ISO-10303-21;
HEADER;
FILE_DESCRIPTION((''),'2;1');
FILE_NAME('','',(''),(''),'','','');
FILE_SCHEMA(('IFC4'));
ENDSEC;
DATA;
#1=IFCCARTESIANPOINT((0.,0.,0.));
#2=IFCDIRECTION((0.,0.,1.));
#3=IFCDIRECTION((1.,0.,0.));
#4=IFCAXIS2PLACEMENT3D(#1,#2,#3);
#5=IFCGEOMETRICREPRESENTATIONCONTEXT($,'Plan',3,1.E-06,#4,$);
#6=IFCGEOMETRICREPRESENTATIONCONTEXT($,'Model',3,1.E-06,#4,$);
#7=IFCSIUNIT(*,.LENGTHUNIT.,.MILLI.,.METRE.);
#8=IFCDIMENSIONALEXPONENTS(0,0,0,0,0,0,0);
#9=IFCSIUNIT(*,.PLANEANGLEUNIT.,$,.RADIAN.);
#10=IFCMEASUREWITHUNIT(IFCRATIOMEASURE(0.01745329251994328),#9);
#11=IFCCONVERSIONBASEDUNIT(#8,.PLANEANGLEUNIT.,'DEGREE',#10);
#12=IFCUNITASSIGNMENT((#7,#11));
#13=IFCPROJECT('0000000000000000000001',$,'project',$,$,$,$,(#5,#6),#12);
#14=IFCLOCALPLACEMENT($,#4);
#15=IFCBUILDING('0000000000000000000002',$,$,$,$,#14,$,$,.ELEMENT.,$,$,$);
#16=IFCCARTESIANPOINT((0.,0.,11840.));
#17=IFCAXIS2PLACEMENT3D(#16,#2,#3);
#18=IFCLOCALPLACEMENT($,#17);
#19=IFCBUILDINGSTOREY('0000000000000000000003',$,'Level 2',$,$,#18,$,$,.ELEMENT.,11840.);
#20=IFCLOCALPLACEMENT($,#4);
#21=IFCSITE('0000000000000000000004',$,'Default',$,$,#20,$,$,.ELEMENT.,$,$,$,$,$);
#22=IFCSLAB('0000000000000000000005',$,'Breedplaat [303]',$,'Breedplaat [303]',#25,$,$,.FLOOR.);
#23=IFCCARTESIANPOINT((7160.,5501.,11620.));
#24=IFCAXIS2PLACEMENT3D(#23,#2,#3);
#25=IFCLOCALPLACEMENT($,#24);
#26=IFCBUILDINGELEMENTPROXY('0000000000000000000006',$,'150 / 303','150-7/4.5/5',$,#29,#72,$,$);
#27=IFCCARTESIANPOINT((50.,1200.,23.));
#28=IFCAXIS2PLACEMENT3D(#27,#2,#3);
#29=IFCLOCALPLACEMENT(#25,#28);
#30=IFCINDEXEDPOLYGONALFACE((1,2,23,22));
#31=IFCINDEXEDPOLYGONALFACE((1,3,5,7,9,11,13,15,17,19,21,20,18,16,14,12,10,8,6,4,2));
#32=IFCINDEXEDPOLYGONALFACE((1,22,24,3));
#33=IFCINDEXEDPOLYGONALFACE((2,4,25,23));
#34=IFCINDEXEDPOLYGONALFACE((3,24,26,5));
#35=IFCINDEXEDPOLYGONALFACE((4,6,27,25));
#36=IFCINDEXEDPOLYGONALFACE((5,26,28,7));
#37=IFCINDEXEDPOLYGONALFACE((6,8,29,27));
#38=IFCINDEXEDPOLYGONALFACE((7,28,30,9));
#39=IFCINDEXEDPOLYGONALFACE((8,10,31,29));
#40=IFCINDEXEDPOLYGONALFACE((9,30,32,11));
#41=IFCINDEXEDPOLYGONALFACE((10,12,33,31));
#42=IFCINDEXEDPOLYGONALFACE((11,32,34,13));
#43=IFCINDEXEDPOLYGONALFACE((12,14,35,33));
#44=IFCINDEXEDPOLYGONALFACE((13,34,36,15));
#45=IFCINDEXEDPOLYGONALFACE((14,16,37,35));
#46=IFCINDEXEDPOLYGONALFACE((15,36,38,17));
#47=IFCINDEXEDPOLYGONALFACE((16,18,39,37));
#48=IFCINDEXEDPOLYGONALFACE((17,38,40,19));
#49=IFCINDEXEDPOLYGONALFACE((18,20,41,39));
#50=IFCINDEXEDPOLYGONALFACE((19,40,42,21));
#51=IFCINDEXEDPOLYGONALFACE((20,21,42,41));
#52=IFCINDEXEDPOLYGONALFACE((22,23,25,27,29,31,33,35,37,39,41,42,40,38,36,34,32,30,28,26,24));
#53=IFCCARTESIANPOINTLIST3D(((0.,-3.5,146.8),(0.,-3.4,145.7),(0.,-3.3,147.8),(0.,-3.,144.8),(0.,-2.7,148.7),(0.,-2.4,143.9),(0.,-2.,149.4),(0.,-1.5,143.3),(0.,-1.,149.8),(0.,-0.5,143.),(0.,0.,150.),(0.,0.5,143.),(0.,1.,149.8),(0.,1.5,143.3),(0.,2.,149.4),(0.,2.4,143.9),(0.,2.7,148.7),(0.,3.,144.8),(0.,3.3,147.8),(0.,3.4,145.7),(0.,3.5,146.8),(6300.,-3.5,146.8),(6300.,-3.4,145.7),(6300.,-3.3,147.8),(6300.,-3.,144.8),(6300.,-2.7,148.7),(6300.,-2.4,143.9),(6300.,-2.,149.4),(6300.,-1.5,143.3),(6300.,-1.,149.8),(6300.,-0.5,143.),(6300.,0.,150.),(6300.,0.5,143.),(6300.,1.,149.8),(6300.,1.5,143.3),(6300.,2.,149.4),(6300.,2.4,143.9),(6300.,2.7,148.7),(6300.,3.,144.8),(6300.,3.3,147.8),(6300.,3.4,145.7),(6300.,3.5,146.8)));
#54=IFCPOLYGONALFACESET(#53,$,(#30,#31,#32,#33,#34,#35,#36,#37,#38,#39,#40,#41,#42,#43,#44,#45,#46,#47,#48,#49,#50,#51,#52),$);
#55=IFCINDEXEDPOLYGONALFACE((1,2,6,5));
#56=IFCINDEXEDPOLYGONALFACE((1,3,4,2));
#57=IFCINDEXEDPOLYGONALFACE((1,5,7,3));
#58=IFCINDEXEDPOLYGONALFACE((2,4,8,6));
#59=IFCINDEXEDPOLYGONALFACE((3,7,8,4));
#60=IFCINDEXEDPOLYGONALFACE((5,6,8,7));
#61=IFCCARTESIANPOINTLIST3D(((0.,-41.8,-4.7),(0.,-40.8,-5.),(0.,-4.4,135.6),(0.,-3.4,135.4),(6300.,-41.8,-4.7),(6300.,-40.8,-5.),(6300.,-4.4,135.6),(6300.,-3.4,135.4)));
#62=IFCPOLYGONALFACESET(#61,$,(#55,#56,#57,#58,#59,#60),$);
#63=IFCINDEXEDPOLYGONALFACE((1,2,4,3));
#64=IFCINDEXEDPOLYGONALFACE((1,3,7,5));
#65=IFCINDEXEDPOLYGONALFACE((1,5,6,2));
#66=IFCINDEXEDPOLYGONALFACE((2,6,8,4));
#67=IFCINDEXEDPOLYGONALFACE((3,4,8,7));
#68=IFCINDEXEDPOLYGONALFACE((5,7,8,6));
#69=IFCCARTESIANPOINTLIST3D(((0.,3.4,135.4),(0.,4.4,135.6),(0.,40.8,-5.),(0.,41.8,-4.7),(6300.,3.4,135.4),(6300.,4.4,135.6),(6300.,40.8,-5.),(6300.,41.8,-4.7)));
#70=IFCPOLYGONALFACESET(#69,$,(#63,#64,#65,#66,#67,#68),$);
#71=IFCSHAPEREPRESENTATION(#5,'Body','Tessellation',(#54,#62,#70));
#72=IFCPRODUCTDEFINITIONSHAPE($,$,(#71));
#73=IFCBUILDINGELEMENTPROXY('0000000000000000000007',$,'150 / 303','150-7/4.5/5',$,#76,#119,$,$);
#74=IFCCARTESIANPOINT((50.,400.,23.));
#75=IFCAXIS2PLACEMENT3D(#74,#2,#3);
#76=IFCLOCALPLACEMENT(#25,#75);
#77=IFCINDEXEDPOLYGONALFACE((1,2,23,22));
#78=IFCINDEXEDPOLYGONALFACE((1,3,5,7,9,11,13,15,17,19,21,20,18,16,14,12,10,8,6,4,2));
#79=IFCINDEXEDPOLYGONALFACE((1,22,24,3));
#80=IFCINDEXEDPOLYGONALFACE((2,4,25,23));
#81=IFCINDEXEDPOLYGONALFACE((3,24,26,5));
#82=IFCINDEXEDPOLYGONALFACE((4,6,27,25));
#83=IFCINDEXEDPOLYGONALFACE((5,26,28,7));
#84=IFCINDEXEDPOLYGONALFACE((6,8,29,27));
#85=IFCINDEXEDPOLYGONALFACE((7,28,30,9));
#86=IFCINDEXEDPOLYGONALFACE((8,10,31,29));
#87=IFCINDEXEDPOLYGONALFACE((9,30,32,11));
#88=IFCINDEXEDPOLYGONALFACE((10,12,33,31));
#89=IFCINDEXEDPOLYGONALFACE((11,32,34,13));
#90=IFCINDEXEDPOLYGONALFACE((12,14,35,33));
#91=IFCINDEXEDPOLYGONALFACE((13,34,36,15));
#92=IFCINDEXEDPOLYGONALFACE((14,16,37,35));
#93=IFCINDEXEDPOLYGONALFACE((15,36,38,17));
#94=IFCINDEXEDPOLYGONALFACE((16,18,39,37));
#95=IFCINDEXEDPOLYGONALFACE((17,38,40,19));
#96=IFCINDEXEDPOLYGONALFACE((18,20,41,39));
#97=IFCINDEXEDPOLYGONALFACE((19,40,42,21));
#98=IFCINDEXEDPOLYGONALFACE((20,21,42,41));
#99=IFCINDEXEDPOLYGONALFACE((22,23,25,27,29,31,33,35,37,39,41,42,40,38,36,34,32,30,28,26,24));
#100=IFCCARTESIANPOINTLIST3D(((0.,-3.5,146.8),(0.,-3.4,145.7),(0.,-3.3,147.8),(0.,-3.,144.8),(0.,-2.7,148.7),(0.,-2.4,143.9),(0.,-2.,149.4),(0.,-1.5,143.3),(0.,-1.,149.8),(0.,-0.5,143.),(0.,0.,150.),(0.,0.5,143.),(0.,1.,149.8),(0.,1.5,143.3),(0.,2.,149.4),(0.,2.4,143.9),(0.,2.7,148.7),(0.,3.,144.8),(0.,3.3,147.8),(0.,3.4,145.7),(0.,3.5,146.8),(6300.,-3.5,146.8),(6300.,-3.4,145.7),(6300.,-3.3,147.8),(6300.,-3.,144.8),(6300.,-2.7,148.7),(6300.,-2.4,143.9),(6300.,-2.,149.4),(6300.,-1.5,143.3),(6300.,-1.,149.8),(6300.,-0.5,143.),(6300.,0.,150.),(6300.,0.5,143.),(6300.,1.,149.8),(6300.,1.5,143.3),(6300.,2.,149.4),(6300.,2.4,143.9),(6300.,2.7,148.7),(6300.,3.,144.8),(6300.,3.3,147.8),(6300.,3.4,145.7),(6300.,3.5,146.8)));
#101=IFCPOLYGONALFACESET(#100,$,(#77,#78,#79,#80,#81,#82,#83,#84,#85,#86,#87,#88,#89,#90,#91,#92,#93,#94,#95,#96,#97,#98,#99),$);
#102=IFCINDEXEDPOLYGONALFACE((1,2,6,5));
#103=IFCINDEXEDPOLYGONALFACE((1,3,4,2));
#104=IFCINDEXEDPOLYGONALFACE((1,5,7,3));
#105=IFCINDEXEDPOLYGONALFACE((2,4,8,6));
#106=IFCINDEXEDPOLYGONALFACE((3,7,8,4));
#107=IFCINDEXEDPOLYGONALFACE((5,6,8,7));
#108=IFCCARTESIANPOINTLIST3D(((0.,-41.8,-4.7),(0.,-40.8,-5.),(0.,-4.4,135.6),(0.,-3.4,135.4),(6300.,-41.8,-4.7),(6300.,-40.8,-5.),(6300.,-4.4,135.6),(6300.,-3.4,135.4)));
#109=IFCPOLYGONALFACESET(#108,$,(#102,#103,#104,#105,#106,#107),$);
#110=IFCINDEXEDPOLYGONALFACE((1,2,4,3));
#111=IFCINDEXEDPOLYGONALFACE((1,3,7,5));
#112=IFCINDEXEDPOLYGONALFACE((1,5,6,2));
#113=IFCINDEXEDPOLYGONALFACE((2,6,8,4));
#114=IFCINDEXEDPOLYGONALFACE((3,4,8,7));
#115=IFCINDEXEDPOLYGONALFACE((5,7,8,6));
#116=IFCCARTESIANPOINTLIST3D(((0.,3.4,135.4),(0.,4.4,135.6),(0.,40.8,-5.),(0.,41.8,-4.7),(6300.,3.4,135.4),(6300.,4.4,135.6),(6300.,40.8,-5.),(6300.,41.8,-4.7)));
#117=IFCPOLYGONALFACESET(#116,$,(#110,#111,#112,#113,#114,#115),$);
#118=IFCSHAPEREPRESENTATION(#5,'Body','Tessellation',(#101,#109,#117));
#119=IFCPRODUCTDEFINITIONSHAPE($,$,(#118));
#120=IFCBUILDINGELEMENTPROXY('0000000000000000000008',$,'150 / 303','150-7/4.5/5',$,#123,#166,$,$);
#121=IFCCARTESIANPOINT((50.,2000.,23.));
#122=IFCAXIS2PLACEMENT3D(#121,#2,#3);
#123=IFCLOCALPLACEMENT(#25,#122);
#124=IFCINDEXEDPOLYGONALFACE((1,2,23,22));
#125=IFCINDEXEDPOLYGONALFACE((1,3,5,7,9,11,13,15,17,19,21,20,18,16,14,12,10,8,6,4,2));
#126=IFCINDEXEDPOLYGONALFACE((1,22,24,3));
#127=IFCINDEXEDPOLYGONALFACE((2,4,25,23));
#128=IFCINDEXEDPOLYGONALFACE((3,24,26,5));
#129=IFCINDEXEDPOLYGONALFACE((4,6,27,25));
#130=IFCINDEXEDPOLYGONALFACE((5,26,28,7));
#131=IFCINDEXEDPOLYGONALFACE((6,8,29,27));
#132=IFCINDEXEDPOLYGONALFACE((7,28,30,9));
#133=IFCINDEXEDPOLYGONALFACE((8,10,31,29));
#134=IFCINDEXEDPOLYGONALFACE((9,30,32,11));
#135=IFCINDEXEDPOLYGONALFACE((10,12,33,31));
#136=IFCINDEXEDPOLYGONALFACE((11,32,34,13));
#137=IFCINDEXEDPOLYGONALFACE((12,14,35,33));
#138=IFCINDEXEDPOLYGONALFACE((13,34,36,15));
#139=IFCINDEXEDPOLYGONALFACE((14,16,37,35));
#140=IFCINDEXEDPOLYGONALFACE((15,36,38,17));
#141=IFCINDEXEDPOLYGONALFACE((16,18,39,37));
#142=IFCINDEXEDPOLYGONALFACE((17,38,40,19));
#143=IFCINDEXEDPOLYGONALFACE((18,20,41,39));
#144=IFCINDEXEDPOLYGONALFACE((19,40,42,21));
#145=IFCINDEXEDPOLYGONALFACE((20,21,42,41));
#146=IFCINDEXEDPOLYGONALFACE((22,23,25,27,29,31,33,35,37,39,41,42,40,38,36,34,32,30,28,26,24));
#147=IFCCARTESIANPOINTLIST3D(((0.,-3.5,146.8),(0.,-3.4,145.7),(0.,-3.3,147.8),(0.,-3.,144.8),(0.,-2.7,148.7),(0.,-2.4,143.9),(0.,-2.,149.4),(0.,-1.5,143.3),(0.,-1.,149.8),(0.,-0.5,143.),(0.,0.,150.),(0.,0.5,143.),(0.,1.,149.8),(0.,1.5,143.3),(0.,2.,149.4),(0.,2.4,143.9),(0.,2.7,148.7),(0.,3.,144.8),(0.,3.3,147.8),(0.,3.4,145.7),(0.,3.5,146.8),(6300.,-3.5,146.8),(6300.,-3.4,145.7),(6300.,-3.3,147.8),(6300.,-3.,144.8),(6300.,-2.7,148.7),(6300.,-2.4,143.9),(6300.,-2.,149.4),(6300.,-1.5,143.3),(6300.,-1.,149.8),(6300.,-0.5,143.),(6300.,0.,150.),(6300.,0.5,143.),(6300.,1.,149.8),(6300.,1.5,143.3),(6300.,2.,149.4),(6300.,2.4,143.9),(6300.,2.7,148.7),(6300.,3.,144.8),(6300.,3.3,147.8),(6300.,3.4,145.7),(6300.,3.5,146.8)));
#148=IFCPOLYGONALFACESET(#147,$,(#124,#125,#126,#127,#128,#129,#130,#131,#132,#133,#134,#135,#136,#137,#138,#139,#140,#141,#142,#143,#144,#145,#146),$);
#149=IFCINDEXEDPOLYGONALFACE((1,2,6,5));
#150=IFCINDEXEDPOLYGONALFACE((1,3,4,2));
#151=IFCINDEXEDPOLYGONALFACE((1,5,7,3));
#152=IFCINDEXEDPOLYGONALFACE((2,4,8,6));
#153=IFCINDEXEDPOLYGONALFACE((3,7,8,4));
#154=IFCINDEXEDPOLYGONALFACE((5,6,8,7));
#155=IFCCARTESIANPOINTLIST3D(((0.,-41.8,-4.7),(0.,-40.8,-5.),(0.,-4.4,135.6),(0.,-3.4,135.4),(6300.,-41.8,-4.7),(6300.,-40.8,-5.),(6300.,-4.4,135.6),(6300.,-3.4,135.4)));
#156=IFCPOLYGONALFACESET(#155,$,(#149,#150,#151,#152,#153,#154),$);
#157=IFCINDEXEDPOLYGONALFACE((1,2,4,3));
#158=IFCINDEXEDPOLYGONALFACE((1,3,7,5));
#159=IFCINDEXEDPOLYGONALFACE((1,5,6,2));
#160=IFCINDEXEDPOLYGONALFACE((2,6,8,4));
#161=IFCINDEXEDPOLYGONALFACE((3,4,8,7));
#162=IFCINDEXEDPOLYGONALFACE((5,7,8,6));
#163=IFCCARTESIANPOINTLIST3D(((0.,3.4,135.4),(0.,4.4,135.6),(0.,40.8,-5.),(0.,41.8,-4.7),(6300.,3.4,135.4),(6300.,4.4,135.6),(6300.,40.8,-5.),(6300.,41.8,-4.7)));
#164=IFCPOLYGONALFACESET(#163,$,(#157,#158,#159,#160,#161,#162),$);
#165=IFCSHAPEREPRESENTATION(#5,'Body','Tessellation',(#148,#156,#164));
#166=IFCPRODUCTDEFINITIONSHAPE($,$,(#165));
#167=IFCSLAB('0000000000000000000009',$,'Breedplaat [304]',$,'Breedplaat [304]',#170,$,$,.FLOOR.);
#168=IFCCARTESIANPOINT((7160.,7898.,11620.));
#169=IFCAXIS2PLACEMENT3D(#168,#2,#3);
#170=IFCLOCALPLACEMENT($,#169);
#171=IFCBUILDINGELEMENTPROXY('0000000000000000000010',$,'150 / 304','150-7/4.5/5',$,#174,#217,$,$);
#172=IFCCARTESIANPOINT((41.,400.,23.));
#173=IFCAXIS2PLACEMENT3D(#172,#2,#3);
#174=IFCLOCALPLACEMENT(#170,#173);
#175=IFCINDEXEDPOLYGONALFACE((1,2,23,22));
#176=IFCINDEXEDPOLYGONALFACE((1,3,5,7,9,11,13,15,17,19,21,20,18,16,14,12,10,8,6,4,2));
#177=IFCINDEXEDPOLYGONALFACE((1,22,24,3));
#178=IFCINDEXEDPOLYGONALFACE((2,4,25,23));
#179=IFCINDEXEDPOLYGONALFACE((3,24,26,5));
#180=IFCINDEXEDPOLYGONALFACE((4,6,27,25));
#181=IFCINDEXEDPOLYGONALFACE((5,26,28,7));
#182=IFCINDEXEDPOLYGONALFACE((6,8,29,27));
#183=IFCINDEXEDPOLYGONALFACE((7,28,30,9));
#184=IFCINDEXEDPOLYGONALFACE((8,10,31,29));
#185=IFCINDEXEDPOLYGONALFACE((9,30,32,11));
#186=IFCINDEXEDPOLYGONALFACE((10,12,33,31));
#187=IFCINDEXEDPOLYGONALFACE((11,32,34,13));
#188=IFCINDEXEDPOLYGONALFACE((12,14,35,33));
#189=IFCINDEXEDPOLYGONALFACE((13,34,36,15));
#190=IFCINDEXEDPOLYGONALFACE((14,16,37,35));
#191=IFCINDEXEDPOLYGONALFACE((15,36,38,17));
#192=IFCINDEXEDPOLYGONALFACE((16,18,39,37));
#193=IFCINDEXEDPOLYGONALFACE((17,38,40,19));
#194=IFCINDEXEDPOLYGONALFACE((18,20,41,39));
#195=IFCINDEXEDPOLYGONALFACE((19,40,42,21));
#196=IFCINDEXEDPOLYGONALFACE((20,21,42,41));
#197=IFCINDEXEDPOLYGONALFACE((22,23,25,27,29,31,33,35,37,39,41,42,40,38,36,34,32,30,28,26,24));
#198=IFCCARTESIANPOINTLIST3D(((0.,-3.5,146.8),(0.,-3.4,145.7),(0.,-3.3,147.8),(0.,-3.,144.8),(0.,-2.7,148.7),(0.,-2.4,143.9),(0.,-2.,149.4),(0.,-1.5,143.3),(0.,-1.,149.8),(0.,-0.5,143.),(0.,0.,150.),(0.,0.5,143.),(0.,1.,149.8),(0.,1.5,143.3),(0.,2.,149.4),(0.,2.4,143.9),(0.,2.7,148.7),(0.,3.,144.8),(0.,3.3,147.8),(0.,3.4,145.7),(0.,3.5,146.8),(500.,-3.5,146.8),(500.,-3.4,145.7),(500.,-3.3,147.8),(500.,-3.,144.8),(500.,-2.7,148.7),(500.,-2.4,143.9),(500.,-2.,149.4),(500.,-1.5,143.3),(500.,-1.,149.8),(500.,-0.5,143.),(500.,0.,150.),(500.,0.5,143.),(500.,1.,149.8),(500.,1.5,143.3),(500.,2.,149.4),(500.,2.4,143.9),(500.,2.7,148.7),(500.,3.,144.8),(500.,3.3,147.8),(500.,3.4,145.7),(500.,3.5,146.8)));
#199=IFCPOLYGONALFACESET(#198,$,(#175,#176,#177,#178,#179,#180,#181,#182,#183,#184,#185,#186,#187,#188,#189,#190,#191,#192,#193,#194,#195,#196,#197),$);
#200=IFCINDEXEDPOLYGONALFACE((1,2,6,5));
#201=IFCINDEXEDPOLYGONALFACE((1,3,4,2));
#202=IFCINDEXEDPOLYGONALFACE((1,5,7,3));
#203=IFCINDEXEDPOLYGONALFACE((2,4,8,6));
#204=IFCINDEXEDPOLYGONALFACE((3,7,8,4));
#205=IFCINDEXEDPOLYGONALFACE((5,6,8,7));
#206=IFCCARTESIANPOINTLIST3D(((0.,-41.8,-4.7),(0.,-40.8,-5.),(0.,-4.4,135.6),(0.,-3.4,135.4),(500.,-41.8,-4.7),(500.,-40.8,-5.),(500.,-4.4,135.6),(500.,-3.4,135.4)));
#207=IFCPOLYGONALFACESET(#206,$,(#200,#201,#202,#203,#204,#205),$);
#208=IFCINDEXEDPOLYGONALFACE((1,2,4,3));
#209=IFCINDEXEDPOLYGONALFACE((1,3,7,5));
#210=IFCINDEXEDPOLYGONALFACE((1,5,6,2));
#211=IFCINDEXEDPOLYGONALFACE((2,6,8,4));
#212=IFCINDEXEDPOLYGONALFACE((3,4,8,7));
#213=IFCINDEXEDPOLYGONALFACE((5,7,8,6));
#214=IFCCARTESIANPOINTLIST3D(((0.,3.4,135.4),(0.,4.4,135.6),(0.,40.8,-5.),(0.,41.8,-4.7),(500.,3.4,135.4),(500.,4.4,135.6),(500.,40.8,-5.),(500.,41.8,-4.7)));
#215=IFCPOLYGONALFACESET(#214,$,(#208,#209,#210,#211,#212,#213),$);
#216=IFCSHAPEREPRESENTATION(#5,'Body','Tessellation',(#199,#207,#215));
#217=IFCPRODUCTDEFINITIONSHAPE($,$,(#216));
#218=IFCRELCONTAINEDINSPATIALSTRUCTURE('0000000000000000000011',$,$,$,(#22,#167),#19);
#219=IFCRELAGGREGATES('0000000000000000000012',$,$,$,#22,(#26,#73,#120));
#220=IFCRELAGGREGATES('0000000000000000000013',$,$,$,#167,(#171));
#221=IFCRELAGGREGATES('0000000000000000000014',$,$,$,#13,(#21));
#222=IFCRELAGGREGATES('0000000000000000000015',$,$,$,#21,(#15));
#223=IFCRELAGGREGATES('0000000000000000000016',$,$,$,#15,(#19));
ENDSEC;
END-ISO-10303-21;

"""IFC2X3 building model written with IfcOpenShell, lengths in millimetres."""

from ifc_helpers import new_model, entity, si_unit, converted_unit, frame, origin_with_axes, origin_2d_with_axis, place, context, project, spatial, rectangle, circle, extrude, element, aggregate, save


model = new_model("IFC2X3")

# Units and contexts
plan_context = context("Plan", 3, precision=1e-06, world=origin_with_axes())
model_context = context("Model", 3, precision=1e-06, world=origin_with_axes())
ifc_project = project(units=[si_unit("LENGTHUNIT", "METRE", prefix="MILLI"), converted_unit("PLANEANGLEUNIT", "DEGREE", entity("IfcRatioMeasure", 0.01745329251994328), si_unit("PLANEANGLEUNIT", "RADIAN"), dimensions=[0, 0, 0, 0, 0, 0, 0])], contexts=[plan_context, model_context])

# Site, building, storey
site_placement = place(None, origin_with_axes())
site = spatial("IfcSite", under=ifc_project, at=site_placement, Name="Default", CompositionType="ELEMENT")
building_placement = place(None, origin_with_axes())
building = spatial("IfcBuilding", under=site, at=building_placement, CompositionType="ELEMENT")
storey_placement = place(None, frame((0.0, 0.0, 11840.0), z_axis=(0.0, 0.0, 1.0), x_axis=(1.0, 0.0, 0.0)))
storey = spatial("IfcBuildingStorey", under=building, at=storey_placement, Name="Level 2", CompositionType="ELEMENT", Elevation=11840.0)

# Slabs, building element proxies
slab_1_placement = place(None, frame((7160.0, 5501.0, 11620.0), z_axis=(0.0, 0.0, 1.0), x_axis=(1.0, 0.0, 0.0)))
slab_1 = element("IfcSlab", 1, at=slab_1_placement, inside=storey, Name="Breedplaat [303]", ObjectType="Breedplaat [303]", PredefinedType="FLOOR")
proxy_1_placement = place(slab_1_placement, frame((50.0, 1200.0, 23.0), z_axis=(0.0, 0.0, 1.0), x_axis=(1.0, 0.0, 0.0)))
proxy_1 = element("IfcBuildingElementProxy", 2, at=proxy_1_placement, Name="150 / 303", Description="150-7/4.5/5", context=plan_context, shape_type="SweptSolid", body=[
    extrude(circle(Radius=3.5, at=origin_2d_with_axis()), frame((0.0, 0.0, 146.5), z_axis=(1.0, 0.0, 0.0), x_axis=(0.0, 0.0, 1.0)), (0.0, 0.0, 1.0), 6300.0),
    extrude(rectangle(XDim=145.2, YDim=1.0, at=origin_2d_with_axis()), frame((0.0, -22.6, 65.3), z_axis=(1.0, 0.0, 0.0), x_axis=(0.0, 0.257663, 0.966235)), (0.0, 0.0, 1.0), 6300.0),
    extrude(rectangle(XDim=145.2, YDim=1.0, at=origin_2d_with_axis()), frame((0.0, 22.6, 65.3), z_axis=(1.0, 0.0, 0.0), x_axis=(0.0, -0.257663, 0.966235)), (0.0, 0.0, 1.0), 6300.0),
])
proxy_2_placement = place(slab_1_placement, frame((50.0, 400.0, 23.0), z_axis=(0.0, 0.0, 1.0), x_axis=(1.0, 0.0, 0.0)))
proxy_2 = element("IfcBuildingElementProxy", 3, at=proxy_2_placement, Name="150 / 303", Description="150-7/4.5/5", context=plan_context, shape_type="SweptSolid", body=[
    extrude(circle(Radius=3.5, at=origin_2d_with_axis()), frame((0.0, 0.0, 146.5), z_axis=(1.0, 0.0, 0.0), x_axis=(0.0, 0.0, 1.0)), (0.0, 0.0, 1.0), 6300.0),
    extrude(rectangle(XDim=145.2, YDim=1.0, at=origin_2d_with_axis()), frame((0.0, -22.6, 65.3), z_axis=(1.0, 0.0, 0.0), x_axis=(0.0, 0.257663, 0.966235)), (0.0, 0.0, 1.0), 6300.0),
    extrude(rectangle(XDim=145.2, YDim=1.0, at=origin_2d_with_axis()), frame((0.0, 22.6, 65.3), z_axis=(1.0, 0.0, 0.0), x_axis=(0.0, -0.257663, 0.966235)), (0.0, 0.0, 1.0), 6300.0),
])
proxy_3_placement = place(slab_1_placement, frame((50.0, 2000.0, 23.0), z_axis=(0.0, 0.0, 1.0), x_axis=(1.0, 0.0, 0.0)))
proxy_3 = element("IfcBuildingElementProxy", 4, at=proxy_3_placement, Name="150 / 303", Description="150-7/4.5/5", context=plan_context, shape_type="SweptSolid", body=[
    extrude(circle(Radius=3.5, at=origin_2d_with_axis()), frame((0.0, 0.0, 146.5), z_axis=(1.0, 0.0, 0.0), x_axis=(0.0, 0.0, 1.0)), (0.0, 0.0, 1.0), 6300.0),
    extrude(rectangle(XDim=145.2, YDim=1.0, at=origin_2d_with_axis()), frame((0.0, -22.6, 65.3), z_axis=(1.0, 0.0, 0.0), x_axis=(0.0, 0.257663, 0.966235)), (0.0, 0.0, 1.0), 6300.0),
    extrude(rectangle(XDim=145.2, YDim=1.0, at=origin_2d_with_axis()), frame((0.0, 22.6, 65.3), z_axis=(1.0, 0.0, 0.0), x_axis=(0.0, -0.257663, 0.966235)), (0.0, 0.0, 1.0), 6300.0),
])
aggregate(slab_1, [proxy_1, proxy_2, proxy_3])
slab_2_placement = place(None, frame((7160.0, 7898.0, 11620.0), z_axis=(0.0, 0.0, 1.0), x_axis=(1.0, 0.0, 0.0)))
slab_2 = element("IfcSlab", 5, at=slab_2_placement, inside=storey, Name="Breedplaat [304]", ObjectType="Breedplaat [304]", PredefinedType="FLOOR")
proxy_4_placement = place(slab_2_placement, frame((41.0, 400.0, 23.0), z_axis=(0.0, 0.0, 1.0), x_axis=(1.0, 0.0, 0.0)))
proxy_4 = element("IfcBuildingElementProxy", 6, at=proxy_4_placement, Name="150 / 304", Description="150-7/4.5/5", context=plan_context, shape_type="SweptSolid", body=[
    extrude(circle(Radius=3.5, at=origin_2d_with_axis()), frame((0.0, 0.0, 146.5), z_axis=(1.0, 0.0, 0.0), x_axis=(0.0, 0.0, 1.0)), (0.0, 0.0, 1.0), 500.0),
    extrude(rectangle(XDim=145.2, YDim=1.0, at=origin_2d_with_axis()), frame((0.0, -22.6, 65.3), z_axis=(1.0, 0.0, 0.0), x_axis=(0.0, 0.257663, 0.966235)), (0.0, 0.0, 1.0), 500.0),
    extrude(rectangle(XDim=145.2, YDim=1.0, at=origin_2d_with_axis()), frame((0.0, 22.6, 65.3), z_axis=(1.0, 0.0, 0.0), x_axis=(0.0, -0.257663, 0.966235)), (0.0, 0.0, 1.0), 500.0),
])
aggregate(slab_2, [proxy_4])

save(model, "model.ifc")
